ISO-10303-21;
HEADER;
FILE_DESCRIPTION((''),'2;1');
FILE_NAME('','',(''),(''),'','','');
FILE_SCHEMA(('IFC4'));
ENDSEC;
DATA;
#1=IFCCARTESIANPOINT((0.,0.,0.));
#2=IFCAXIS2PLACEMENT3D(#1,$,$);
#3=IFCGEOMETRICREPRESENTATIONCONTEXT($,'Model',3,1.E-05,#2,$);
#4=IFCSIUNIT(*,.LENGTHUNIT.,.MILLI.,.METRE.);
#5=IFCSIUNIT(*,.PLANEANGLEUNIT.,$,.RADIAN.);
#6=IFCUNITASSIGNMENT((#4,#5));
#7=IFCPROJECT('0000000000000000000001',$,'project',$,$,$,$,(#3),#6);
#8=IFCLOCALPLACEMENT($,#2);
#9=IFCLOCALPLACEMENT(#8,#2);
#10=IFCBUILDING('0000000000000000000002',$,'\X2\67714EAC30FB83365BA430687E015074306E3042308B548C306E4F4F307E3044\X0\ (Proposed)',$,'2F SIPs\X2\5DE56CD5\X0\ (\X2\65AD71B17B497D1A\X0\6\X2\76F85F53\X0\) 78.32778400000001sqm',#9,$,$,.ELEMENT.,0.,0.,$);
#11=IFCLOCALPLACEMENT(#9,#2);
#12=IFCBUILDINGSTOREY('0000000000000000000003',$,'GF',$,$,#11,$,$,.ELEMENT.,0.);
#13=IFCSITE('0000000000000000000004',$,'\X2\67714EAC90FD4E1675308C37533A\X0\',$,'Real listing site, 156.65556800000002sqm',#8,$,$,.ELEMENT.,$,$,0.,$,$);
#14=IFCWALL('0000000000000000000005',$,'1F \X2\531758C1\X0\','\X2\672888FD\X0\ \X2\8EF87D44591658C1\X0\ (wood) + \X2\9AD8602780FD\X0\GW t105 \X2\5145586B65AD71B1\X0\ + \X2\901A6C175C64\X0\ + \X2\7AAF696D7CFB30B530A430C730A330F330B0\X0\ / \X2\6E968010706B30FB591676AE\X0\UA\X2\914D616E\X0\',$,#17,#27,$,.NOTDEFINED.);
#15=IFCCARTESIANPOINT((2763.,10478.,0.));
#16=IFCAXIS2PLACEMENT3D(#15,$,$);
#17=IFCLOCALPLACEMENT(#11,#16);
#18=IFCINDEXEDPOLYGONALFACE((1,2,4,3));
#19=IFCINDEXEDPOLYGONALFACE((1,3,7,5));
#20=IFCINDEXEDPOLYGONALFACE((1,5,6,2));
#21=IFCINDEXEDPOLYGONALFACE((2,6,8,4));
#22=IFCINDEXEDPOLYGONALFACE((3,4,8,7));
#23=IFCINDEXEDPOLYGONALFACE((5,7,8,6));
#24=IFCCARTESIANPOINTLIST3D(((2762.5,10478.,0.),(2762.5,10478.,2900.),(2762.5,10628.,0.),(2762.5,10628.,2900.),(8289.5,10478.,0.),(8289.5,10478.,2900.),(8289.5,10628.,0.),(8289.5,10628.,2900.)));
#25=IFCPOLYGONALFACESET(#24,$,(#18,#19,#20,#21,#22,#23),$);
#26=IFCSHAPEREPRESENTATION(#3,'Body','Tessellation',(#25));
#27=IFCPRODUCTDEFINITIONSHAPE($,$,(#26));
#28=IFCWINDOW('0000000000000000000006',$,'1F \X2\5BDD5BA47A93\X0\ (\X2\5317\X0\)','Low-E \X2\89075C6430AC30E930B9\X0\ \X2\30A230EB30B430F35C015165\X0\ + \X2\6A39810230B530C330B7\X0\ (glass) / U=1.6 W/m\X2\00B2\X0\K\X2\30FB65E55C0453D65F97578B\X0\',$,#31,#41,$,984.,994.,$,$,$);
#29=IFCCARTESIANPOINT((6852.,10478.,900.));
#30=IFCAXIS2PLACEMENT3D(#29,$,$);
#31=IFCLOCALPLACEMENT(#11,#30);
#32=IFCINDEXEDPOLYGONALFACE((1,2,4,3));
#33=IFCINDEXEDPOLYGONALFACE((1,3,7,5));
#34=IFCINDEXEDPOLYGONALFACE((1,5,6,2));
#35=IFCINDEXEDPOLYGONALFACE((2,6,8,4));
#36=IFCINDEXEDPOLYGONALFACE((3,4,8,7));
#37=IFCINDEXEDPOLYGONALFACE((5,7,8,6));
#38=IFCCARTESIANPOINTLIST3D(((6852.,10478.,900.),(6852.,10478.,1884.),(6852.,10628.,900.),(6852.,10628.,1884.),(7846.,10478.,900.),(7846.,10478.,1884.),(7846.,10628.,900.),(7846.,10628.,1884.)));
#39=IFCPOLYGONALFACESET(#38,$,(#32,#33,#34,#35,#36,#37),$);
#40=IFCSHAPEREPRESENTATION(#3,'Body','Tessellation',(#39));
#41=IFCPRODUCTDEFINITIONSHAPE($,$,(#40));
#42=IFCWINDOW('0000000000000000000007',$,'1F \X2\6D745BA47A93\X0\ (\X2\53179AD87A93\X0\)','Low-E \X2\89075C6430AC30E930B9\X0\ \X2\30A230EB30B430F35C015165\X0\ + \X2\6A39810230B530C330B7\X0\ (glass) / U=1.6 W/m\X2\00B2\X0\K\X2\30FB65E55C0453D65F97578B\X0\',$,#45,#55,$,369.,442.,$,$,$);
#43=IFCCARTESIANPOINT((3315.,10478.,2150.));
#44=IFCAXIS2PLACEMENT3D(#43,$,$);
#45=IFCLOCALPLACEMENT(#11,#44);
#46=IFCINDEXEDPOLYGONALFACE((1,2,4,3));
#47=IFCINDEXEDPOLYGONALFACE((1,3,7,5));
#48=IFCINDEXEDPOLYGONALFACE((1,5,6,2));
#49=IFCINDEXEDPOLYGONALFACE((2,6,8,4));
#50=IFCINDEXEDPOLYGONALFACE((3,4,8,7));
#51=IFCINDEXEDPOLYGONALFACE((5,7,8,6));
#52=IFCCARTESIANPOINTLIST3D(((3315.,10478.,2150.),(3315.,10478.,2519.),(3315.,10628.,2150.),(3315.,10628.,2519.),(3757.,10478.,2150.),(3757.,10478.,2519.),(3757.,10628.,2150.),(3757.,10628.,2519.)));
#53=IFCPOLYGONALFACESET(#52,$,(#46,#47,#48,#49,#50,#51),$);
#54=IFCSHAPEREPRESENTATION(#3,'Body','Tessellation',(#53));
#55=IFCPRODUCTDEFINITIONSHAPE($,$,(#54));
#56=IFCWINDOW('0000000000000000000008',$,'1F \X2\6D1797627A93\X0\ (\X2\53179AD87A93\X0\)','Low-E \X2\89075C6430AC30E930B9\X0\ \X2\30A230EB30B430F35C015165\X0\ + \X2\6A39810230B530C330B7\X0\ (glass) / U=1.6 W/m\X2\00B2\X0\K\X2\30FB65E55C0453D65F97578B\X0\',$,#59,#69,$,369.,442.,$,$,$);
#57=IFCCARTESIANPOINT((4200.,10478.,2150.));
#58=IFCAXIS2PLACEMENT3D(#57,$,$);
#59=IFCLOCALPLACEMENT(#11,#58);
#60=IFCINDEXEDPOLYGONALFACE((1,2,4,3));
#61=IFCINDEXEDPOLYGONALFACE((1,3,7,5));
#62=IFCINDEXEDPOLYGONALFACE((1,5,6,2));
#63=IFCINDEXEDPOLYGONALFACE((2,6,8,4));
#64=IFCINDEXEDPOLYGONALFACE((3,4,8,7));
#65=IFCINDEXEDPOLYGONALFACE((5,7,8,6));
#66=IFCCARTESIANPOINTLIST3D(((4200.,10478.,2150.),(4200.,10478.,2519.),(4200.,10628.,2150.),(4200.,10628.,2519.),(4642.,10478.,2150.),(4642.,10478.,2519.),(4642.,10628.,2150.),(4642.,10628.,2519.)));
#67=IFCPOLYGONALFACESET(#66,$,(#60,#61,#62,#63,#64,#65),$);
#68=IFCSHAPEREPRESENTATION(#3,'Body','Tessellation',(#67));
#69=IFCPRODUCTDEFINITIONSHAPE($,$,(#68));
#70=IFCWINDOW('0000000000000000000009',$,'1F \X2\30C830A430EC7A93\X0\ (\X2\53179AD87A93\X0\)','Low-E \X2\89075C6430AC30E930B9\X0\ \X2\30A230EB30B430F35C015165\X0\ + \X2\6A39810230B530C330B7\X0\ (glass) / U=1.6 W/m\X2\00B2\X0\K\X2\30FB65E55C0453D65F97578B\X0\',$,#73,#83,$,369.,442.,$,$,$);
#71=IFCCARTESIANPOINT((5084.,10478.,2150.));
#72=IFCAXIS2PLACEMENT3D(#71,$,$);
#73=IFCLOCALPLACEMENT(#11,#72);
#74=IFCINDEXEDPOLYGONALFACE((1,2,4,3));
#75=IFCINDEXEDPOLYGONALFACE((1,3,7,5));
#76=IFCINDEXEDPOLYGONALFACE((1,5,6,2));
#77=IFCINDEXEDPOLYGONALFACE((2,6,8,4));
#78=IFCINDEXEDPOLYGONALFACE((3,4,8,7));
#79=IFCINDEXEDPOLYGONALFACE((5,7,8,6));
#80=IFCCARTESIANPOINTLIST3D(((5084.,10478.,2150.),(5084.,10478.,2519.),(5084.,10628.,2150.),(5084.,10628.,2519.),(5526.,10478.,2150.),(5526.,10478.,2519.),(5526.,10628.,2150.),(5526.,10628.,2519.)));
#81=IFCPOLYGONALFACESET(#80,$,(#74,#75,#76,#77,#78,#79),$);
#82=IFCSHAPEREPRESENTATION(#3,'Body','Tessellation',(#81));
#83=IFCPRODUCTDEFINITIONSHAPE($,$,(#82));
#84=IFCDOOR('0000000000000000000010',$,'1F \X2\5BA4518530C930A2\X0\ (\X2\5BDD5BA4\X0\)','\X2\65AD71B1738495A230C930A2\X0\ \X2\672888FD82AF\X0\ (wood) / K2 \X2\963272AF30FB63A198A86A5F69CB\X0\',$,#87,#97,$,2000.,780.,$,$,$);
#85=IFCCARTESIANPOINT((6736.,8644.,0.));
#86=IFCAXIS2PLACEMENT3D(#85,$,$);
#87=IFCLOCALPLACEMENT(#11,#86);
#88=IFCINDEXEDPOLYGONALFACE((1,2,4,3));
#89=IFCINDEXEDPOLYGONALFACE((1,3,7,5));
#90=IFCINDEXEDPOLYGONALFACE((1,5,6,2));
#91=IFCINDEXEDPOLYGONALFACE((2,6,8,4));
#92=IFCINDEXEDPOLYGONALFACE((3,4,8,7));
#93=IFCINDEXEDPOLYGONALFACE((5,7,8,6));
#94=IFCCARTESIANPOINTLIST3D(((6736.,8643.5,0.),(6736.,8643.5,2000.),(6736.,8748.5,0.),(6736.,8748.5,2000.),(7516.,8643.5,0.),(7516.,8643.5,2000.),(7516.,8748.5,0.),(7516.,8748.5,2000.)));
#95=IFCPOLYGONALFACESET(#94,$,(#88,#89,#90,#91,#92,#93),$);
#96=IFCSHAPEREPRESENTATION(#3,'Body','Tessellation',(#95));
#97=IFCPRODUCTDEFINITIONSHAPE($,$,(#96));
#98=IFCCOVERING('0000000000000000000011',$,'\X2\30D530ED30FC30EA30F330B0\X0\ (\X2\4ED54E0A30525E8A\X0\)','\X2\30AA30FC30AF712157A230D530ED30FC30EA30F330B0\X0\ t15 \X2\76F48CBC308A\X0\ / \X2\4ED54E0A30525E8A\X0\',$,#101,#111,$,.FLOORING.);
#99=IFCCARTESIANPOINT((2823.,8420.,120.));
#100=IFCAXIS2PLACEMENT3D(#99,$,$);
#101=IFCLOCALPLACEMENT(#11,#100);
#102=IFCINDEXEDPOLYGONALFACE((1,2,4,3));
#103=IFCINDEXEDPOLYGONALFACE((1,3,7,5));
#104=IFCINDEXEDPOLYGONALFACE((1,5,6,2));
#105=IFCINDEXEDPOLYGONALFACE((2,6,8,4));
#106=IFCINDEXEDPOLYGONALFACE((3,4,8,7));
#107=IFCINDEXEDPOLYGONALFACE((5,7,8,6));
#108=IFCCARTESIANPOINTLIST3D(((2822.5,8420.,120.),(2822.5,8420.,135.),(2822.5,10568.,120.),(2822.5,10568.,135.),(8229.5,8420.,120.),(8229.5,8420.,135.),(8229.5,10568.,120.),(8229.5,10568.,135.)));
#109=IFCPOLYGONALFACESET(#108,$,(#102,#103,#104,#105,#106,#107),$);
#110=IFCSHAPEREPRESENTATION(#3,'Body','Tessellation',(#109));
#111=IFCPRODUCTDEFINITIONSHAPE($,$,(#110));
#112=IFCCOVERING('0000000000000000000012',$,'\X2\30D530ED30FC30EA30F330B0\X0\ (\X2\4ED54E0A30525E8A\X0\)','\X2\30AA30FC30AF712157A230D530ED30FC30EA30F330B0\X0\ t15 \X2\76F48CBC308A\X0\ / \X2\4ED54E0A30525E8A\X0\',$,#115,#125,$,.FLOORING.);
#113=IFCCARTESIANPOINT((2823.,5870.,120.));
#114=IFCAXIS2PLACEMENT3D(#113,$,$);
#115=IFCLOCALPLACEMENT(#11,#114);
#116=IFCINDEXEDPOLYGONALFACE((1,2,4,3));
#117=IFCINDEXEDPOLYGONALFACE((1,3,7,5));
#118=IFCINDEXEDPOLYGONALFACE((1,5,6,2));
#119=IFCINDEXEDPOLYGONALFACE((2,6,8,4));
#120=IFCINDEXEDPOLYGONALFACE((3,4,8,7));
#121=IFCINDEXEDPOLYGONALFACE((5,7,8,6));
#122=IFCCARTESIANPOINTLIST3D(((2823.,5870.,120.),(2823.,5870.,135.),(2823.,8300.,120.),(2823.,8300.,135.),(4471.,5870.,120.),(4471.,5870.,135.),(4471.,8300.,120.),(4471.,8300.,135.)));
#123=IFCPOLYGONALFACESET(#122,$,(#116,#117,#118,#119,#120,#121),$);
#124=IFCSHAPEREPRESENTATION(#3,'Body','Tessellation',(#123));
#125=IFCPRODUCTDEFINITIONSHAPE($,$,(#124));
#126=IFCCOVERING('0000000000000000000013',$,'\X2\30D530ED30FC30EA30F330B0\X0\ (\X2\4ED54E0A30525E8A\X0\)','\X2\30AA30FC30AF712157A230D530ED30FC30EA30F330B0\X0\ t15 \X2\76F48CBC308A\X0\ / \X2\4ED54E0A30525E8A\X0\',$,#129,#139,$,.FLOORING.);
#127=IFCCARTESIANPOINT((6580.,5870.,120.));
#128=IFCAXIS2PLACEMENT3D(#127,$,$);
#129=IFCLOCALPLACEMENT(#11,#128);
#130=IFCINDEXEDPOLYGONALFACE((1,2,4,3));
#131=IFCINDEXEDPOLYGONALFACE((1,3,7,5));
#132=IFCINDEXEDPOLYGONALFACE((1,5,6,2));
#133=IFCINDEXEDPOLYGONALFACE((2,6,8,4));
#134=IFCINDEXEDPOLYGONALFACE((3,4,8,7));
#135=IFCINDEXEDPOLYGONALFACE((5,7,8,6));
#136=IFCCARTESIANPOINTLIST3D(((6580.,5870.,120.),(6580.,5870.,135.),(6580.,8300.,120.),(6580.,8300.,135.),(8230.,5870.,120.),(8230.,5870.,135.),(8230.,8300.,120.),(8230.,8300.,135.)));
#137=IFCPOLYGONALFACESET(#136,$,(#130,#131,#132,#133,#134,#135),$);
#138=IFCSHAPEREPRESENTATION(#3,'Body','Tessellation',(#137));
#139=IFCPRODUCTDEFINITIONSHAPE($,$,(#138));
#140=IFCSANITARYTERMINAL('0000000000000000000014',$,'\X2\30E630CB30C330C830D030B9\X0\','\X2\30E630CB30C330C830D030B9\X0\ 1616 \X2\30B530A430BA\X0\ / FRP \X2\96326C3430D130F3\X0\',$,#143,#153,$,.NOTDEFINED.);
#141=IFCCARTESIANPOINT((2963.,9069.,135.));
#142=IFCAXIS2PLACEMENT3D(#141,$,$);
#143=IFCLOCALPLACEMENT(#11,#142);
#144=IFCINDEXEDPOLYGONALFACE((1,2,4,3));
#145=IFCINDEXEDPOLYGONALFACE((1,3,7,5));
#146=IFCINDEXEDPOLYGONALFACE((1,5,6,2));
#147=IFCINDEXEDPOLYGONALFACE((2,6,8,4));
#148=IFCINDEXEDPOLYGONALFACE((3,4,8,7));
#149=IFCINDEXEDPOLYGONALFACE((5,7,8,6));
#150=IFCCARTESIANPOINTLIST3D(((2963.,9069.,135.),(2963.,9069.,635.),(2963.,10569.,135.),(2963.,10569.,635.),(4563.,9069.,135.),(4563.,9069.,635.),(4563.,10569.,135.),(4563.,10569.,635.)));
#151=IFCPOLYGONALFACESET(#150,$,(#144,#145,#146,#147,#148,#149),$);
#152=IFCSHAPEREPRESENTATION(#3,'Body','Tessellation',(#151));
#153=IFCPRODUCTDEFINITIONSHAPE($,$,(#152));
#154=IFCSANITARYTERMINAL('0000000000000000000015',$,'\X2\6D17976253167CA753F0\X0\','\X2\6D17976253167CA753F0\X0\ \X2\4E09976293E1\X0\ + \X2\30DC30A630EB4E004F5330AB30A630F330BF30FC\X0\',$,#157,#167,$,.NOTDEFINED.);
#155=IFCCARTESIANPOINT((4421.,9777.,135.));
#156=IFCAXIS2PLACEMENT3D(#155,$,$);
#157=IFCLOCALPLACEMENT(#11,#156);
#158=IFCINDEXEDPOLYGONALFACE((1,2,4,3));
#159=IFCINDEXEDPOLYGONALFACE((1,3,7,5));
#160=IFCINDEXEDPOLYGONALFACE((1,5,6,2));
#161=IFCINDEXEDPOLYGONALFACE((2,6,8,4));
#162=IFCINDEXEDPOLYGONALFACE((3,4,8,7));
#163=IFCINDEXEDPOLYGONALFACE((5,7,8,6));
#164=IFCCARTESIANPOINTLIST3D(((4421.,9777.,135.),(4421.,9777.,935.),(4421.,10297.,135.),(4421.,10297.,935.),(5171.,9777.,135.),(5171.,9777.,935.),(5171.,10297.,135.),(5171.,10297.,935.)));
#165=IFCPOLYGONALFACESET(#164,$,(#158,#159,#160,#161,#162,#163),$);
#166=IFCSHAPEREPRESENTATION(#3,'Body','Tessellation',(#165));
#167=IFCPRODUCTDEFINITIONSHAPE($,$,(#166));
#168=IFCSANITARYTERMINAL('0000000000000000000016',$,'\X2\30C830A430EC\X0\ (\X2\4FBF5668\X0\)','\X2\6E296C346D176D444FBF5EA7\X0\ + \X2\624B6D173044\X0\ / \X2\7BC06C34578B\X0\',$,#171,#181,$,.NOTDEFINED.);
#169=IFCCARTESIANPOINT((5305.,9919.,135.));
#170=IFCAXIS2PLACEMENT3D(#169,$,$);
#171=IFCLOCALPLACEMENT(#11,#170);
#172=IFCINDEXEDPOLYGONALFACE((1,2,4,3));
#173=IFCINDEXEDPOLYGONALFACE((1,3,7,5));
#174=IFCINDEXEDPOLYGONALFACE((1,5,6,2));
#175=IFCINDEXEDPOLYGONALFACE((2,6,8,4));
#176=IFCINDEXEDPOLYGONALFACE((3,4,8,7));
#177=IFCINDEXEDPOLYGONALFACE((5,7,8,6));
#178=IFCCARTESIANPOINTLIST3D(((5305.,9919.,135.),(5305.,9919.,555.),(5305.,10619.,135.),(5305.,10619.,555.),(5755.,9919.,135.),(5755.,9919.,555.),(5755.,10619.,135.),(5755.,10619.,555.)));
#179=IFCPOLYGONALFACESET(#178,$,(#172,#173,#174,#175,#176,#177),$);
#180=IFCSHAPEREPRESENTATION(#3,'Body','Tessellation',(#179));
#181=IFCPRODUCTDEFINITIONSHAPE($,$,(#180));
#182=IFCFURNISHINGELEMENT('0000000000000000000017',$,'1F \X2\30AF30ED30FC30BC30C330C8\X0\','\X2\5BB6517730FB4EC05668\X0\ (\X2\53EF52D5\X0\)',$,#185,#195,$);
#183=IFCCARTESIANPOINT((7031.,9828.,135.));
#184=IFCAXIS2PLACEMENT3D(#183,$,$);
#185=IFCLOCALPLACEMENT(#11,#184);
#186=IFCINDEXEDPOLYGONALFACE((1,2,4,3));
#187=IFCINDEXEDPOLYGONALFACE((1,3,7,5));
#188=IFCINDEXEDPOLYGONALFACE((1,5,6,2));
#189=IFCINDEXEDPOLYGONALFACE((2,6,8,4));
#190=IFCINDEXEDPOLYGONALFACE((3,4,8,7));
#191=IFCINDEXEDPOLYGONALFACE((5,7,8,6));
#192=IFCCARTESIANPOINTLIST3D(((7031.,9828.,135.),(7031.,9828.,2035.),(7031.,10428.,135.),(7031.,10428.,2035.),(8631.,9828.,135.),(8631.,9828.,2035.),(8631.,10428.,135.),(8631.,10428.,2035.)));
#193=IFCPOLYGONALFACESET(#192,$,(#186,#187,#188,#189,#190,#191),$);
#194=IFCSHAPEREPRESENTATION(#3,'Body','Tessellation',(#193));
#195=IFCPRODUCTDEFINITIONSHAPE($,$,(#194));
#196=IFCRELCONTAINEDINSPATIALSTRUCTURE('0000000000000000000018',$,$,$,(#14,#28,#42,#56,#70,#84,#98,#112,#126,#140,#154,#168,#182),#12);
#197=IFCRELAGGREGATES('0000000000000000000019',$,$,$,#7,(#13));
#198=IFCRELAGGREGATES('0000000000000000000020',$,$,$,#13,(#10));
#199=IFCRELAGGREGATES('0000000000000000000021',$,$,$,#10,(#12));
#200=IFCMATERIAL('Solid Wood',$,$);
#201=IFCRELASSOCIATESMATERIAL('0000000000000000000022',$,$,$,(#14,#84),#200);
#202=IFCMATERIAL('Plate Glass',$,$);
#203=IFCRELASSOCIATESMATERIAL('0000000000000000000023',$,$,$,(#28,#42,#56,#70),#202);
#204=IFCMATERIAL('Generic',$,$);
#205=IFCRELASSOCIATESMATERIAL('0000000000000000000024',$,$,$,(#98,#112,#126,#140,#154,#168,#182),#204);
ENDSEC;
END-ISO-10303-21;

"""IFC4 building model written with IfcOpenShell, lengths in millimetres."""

from ifc_helpers import new_model, si_unit, frame, frame_2d, origin, place, context, project, spatial, rectangle, extrude, material, element, fill, save


model = new_model("IFC4")

# Units and contexts
model_context = context("Model", 3, precision=1e-05, world=origin())
ifc_project = project(units=[si_unit("LENGTHUNIT", "METRE", prefix="MILLI"), si_unit("PLANEANGLEUNIT", "RADIAN")], contexts=[model_context])

# Site, building, storey
site_placement = place(None, origin())
site = spatial("IfcSite", under=ifc_project, at=site_placement, Name="東京都世田谷区", ObjectType="Real listing site, 156.65556800000002sqm", CompositionType="ELEMENT", RefElevation=0.0)
building_placement = place(site_placement, origin())
building = spatial("IfcBuilding", under=site, at=building_placement, Name="東京・茶室と縁側のある和の住まい (Proposed)", ObjectType="2F SIPs工法 (断熱等級6相当) 78.32778400000001sqm", CompositionType="ELEMENT", ElevationOfRefHeight=0.0, ElevationOfTerrain=0.0)
storey_placement = place(building_placement, origin())
storey = spatial("IfcBuildingStorey", under=building, at=storey_placement, Name="GF", CompositionType="ELEMENT", Elevation=0.0)

# Shared definitions
ifc_material_1 = material(Name="Solid Wood")

# Wall, openings, windows
wall_1_placement = place(storey_placement, frame((2763.0, 10478.0, 0.0)))
wall_1 = element("IfcWall", 1, at=wall_1_placement, inside=storey, material=ifc_material_1, Name="1F 北壁", Description="木製 軸組外壁 (wood) + 高性能GW t105 充填断熱 + 通気層 + 窯業系サイディング / 準耐火・外皮UA配慮", PredefinedType="NOTDEFINED", context=model_context, shape_type="SweptSolid", body=[
    extrude(rectangle(XDim=5527.0, YDim=150.0, at=frame_2d((2763.0, 75.0))), frame((2763.0, 10478.0, 0.0)), (0.0, 0.0, 1.0), 2900.0),
])
opening_1_placement = place(storey_placement, frame((6852.0, 10478.0, 900.0)))
opening_1 = element("IfcOpeningElement", 2, at=opening_1_placement, cuts=wall_1, PredefinedType="NOTDEFINED", context=model_context, shape_type="SweptSolid", body=[
    extrude(rectangle(XDim=994.0, YDim=150.0, at=frame_2d((497.0, 75.0))), frame((6852.0, 10478.0, 900.0)), (0.0, 0.0, 1.0), 984.0),
])
opening_2_placement = place(storey_placement, frame((3315.0, 10478.0, 2150.0)))
opening_2 = element("IfcOpeningElement", 3, at=opening_2_placement, cuts=wall_1, PredefinedType="NOTDEFINED", context=model_context, shape_type="SweptSolid", body=[
    extrude(rectangle(XDim=442.0, YDim=150.0, at=frame_2d((221.0, 75.0))), frame((3315.0, 10478.0, 2150.0)), (0.0, 0.0, 1.0), 369.0),
])
opening_3_placement = place(storey_placement, frame((4200.0, 10478.0, 2150.0)))
opening_3 = element("IfcOpeningElement", 4, at=opening_3_placement, cuts=wall_1, PredefinedType="NOTDEFINED", context=model_context, shape_type="SweptSolid", body=[
    extrude(rectangle(XDim=442.0, YDim=150.0, at=frame_2d((221.0, 75.0))), frame((4200.0, 10478.0, 2150.0)), (0.0, 0.0, 1.0), 369.0),
])
opening_4_placement = place(storey_placement, frame((5084.0, 10478.0, 2150.0)))
opening_4 = element("IfcOpeningElement", 5, at=opening_4_placement, cuts=wall_1, PredefinedType="NOTDEFINED", context=model_context, shape_type="SweptSolid", body=[
    extrude(rectangle(XDim=442.0, YDim=150.0, at=frame_2d((221.0, 75.0))), frame((5084.0, 10478.0, 2150.0)), (0.0, 0.0, 1.0), 369.0),
])
ifc_material_2 = material(Name="Plate Glass")
window_1_placement = place(storey_placement, frame((6852.0, 10478.0, 900.0)))
window_1 = element("IfcWindow", 6, at=window_1_placement, inside=storey, material=ifc_material_2, Name="1F 寝室窓 (北)", Description="Low-E 複層ガラス アルゴン封入 + 樹脂サッシ (glass) / U=1.6 W/m²K・日射取得型", OverallHeight=984.0, OverallWidth=994.0, context=model_context, shape_type="SweptSolid", body=[
    extrude(rectangle(XDim=994.0, YDim=150.0, at=frame_2d((497.0, 75.0))), frame((6852.0, 10478.0, 900.0)), (0.0, 0.0, 1.0), 984.0),
])
fill(opening_1, window_1)
window_2_placement = place(storey_placement, frame((3315.0, 10478.0, 2150.0)))
window_2 = element("IfcWindow", 7, at=window_2_placement, inside=storey, material=ifc_material_2, Name="1F 浴室窓 (北高窓)", Description="Low-E 複層ガラス アルゴン封入 + 樹脂サッシ (glass) / U=1.6 W/m²K・日射取得型", OverallHeight=369.0, OverallWidth=442.0, context=model_context, shape_type="SweptSolid", body=[
    extrude(rectangle(XDim=442.0, YDim=150.0, at=frame_2d((221.0, 75.0))), frame((3315.0, 10478.0, 2150.0)), (0.0, 0.0, 1.0), 369.0),
])
fill(opening_2, window_2)
window_3_placement = place(storey_placement, frame((4200.0, 10478.0, 2150.0)))
window_3 = element("IfcWindow", 8, at=window_3_placement, inside=storey, material=ifc_material_2, Name="1F 洗面窓 (北高窓)", Description="Low-E 複層ガラス アルゴン封入 + 樹脂サッシ (glass) / U=1.6 W/m²K・日射取得型", OverallHeight=369.0, OverallWidth=442.0, context=model_context, shape_type="SweptSolid", body=[
    extrude(rectangle(XDim=442.0, YDim=150.0, at=frame_2d((221.0, 75.0))), frame((4200.0, 10478.0, 2150.0)), (0.0, 0.0, 1.0), 369.0),
])
fill(opening_3, window_3)
window_4_placement = place(storey_placement, frame((5084.0, 10478.0, 2150.0)))
window_4 = element("IfcWindow", 9, at=window_4_placement, inside=storey, material=ifc_material_2, Name="1F トイレ窓 (北高窓)", Description="Low-E 複層ガラス アルゴン封入 + 樹脂サッシ (glass) / U=1.6 W/m²K・日射取得型", OverallHeight=369.0, OverallWidth=442.0, context=model_context, shape_type="SweptSolid", body=[
    extrude(rectangle(XDim=442.0, YDim=150.0, at=frame_2d((221.0, 75.0))), frame((5084.0, 10478.0, 2150.0)), (0.0, 0.0, 1.0), 369.0),
])
fill(opening_4, window_4)

# Door
door_1_placement = place(storey_placement, frame((6736.0, 8644.0, 0.0)))
element("IfcDoor", 10, at=door_1_placement, inside=storey, material=ifc_material_1, Name="1F 室内ドア (寝室)", Description="断熱玄関ドア 木製芯 (wood) / K2 防犯・採風機構", OverallHeight=2000.0, OverallWidth=780.0, context=model_context, shape_type="SweptSolid", body=[
    extrude(rectangle(XDim=780.0, YDim=105.0, at=frame_2d((390.0, 52.0))), frame((6736.0, 8644.0, 0.0)), (0.0, 0.0, 1.0), 2000.0),
])

# Coverings
ifc_material_3 = material(Name="Generic")
covering_1_placement = place(storey_placement, frame((2823.0, 8420.0, 120.0)))
element("IfcCovering", 11, at=covering_1_placement, inside=storey, material=ifc_material_3, Name="フローリング (仕上げ床)", Description="オーク無垢フローリング t15 直貼り / 仕上げ床", PredefinedType="FLOORING", context=model_context, shape_type="SweptSolid", body=[
    extrude(rectangle(XDim=5407.0, YDim=2148.0, at=frame_2d((2703.0, 1074.0))), frame((2823.0, 8420.0, 120.0)), (0.0, 0.0, 1.0), 15.0),
])
covering_2_placement = place(storey_placement, frame((2823.0, 5870.0, 120.0)))
element("IfcCovering", 12, at=covering_2_placement, inside=storey, material=ifc_material_3, Name="フローリング (仕上げ床)", Description="オーク無垢フローリング t15 直貼り / 仕上げ床", PredefinedType="FLOORING", context=model_context, shape_type="SweptSolid", body=[
    extrude(rectangle(XDim=1648.0, YDim=2430.0, at=frame_2d((824.0, 1215.0))), frame((2823.0, 5870.0, 120.0)), (0.0, 0.0, 1.0), 15.0),
])
covering_3_placement = place(storey_placement, frame((6580.0, 5870.0, 120.0)))
element("IfcCovering", 13, at=covering_3_placement, inside=storey, material=ifc_material_3, Name="フローリング (仕上げ床)", Description="オーク無垢フローリング t15 直貼り / 仕上げ床", PredefinedType="FLOORING", context=model_context, shape_type="SweptSolid", body=[
    extrude(rectangle(XDim=1650.0, YDim=2430.0, at=frame_2d((825.0, 1215.0))), frame((6580.0, 5870.0, 120.0)), (0.0, 0.0, 1.0), 15.0),
])

# Sanitary terminals
sanitary_terminal_1_placement = place(storey_placement, frame((2963.0, 9069.0, 135.0)))
element("IfcSanitaryTerminal", 14, at=sanitary_terminal_1_placement, inside=storey, material=ifc_material_3, Name="ユニットバス", Description="ユニットバス 1616 サイズ / FRP 防水パン", PredefinedType="NOTDEFINED", context=model_context, shape_type="SweptSolid", body=[
    extrude(rectangle(XDim=1600.0, YDim=1500.0, at=frame_2d((800.0, 750.0))), frame((2963.0, 9069.0, 135.0)), (0.0, 0.0, 1.0), 500.0),
])
sanitary_terminal_2_placement = place(storey_placement, frame((4421.0, 9777.0, 135.0)))
element("IfcSanitaryTerminal", 15, at=sanitary_terminal_2_placement, inside=storey, material=ifc_material_3, Name="洗面化粧台", Description="洗面化粧台 三面鏡 + ボウル一体カウンター", PredefinedType="NOTDEFINED", context=model_context, shape_type="SweptSolid", body=[
    extrude(rectangle(XDim=750.0, YDim=520.0, at=frame_2d((375.0, 260.0))), frame((4421.0, 9777.0, 135.0)), (0.0, 0.0, 1.0), 800.0),
])
sanitary_terminal_3_placement = place(storey_placement, frame((5305.0, 9919.0, 135.0)))
element("IfcSanitaryTerminal", 16, at=sanitary_terminal_3_placement, inside=storey, material=ifc_material_3, Name="トイレ (便器)", Description="温水洗浄便座 + 手洗い / 節水型", PredefinedType="NOTDEFINED", context=model_context, shape_type="SweptSolid", body=[
    extrude(rectangle(XDim=450.0, YDim=700.0, at=frame_2d((225.0, 350.0))), frame((5305.0, 9919.0, 135.0)), (0.0, 0.0, 1.0), 420.0),
])

# Furnishing element
furnishing_placement = place(storey_placement, frame((7031.0, 9828.0, 135.0)))
element("IfcFurnishingElement", 17, at=furnishing_placement, inside=storey, material=ifc_material_3, Name="1F クローゼット", Description="家具・什器 (可動)", context=model_context, shape_type="SweptSolid", body=[
    extrude(rectangle(XDim=1600.0, YDim=600.0, at=frame_2d((800.0, 300.0))), frame((7031.0, 9828.0, 135.0)), (0.0, 0.0, 1.0), 1900.0),
])

save(model, "model.ifc")
